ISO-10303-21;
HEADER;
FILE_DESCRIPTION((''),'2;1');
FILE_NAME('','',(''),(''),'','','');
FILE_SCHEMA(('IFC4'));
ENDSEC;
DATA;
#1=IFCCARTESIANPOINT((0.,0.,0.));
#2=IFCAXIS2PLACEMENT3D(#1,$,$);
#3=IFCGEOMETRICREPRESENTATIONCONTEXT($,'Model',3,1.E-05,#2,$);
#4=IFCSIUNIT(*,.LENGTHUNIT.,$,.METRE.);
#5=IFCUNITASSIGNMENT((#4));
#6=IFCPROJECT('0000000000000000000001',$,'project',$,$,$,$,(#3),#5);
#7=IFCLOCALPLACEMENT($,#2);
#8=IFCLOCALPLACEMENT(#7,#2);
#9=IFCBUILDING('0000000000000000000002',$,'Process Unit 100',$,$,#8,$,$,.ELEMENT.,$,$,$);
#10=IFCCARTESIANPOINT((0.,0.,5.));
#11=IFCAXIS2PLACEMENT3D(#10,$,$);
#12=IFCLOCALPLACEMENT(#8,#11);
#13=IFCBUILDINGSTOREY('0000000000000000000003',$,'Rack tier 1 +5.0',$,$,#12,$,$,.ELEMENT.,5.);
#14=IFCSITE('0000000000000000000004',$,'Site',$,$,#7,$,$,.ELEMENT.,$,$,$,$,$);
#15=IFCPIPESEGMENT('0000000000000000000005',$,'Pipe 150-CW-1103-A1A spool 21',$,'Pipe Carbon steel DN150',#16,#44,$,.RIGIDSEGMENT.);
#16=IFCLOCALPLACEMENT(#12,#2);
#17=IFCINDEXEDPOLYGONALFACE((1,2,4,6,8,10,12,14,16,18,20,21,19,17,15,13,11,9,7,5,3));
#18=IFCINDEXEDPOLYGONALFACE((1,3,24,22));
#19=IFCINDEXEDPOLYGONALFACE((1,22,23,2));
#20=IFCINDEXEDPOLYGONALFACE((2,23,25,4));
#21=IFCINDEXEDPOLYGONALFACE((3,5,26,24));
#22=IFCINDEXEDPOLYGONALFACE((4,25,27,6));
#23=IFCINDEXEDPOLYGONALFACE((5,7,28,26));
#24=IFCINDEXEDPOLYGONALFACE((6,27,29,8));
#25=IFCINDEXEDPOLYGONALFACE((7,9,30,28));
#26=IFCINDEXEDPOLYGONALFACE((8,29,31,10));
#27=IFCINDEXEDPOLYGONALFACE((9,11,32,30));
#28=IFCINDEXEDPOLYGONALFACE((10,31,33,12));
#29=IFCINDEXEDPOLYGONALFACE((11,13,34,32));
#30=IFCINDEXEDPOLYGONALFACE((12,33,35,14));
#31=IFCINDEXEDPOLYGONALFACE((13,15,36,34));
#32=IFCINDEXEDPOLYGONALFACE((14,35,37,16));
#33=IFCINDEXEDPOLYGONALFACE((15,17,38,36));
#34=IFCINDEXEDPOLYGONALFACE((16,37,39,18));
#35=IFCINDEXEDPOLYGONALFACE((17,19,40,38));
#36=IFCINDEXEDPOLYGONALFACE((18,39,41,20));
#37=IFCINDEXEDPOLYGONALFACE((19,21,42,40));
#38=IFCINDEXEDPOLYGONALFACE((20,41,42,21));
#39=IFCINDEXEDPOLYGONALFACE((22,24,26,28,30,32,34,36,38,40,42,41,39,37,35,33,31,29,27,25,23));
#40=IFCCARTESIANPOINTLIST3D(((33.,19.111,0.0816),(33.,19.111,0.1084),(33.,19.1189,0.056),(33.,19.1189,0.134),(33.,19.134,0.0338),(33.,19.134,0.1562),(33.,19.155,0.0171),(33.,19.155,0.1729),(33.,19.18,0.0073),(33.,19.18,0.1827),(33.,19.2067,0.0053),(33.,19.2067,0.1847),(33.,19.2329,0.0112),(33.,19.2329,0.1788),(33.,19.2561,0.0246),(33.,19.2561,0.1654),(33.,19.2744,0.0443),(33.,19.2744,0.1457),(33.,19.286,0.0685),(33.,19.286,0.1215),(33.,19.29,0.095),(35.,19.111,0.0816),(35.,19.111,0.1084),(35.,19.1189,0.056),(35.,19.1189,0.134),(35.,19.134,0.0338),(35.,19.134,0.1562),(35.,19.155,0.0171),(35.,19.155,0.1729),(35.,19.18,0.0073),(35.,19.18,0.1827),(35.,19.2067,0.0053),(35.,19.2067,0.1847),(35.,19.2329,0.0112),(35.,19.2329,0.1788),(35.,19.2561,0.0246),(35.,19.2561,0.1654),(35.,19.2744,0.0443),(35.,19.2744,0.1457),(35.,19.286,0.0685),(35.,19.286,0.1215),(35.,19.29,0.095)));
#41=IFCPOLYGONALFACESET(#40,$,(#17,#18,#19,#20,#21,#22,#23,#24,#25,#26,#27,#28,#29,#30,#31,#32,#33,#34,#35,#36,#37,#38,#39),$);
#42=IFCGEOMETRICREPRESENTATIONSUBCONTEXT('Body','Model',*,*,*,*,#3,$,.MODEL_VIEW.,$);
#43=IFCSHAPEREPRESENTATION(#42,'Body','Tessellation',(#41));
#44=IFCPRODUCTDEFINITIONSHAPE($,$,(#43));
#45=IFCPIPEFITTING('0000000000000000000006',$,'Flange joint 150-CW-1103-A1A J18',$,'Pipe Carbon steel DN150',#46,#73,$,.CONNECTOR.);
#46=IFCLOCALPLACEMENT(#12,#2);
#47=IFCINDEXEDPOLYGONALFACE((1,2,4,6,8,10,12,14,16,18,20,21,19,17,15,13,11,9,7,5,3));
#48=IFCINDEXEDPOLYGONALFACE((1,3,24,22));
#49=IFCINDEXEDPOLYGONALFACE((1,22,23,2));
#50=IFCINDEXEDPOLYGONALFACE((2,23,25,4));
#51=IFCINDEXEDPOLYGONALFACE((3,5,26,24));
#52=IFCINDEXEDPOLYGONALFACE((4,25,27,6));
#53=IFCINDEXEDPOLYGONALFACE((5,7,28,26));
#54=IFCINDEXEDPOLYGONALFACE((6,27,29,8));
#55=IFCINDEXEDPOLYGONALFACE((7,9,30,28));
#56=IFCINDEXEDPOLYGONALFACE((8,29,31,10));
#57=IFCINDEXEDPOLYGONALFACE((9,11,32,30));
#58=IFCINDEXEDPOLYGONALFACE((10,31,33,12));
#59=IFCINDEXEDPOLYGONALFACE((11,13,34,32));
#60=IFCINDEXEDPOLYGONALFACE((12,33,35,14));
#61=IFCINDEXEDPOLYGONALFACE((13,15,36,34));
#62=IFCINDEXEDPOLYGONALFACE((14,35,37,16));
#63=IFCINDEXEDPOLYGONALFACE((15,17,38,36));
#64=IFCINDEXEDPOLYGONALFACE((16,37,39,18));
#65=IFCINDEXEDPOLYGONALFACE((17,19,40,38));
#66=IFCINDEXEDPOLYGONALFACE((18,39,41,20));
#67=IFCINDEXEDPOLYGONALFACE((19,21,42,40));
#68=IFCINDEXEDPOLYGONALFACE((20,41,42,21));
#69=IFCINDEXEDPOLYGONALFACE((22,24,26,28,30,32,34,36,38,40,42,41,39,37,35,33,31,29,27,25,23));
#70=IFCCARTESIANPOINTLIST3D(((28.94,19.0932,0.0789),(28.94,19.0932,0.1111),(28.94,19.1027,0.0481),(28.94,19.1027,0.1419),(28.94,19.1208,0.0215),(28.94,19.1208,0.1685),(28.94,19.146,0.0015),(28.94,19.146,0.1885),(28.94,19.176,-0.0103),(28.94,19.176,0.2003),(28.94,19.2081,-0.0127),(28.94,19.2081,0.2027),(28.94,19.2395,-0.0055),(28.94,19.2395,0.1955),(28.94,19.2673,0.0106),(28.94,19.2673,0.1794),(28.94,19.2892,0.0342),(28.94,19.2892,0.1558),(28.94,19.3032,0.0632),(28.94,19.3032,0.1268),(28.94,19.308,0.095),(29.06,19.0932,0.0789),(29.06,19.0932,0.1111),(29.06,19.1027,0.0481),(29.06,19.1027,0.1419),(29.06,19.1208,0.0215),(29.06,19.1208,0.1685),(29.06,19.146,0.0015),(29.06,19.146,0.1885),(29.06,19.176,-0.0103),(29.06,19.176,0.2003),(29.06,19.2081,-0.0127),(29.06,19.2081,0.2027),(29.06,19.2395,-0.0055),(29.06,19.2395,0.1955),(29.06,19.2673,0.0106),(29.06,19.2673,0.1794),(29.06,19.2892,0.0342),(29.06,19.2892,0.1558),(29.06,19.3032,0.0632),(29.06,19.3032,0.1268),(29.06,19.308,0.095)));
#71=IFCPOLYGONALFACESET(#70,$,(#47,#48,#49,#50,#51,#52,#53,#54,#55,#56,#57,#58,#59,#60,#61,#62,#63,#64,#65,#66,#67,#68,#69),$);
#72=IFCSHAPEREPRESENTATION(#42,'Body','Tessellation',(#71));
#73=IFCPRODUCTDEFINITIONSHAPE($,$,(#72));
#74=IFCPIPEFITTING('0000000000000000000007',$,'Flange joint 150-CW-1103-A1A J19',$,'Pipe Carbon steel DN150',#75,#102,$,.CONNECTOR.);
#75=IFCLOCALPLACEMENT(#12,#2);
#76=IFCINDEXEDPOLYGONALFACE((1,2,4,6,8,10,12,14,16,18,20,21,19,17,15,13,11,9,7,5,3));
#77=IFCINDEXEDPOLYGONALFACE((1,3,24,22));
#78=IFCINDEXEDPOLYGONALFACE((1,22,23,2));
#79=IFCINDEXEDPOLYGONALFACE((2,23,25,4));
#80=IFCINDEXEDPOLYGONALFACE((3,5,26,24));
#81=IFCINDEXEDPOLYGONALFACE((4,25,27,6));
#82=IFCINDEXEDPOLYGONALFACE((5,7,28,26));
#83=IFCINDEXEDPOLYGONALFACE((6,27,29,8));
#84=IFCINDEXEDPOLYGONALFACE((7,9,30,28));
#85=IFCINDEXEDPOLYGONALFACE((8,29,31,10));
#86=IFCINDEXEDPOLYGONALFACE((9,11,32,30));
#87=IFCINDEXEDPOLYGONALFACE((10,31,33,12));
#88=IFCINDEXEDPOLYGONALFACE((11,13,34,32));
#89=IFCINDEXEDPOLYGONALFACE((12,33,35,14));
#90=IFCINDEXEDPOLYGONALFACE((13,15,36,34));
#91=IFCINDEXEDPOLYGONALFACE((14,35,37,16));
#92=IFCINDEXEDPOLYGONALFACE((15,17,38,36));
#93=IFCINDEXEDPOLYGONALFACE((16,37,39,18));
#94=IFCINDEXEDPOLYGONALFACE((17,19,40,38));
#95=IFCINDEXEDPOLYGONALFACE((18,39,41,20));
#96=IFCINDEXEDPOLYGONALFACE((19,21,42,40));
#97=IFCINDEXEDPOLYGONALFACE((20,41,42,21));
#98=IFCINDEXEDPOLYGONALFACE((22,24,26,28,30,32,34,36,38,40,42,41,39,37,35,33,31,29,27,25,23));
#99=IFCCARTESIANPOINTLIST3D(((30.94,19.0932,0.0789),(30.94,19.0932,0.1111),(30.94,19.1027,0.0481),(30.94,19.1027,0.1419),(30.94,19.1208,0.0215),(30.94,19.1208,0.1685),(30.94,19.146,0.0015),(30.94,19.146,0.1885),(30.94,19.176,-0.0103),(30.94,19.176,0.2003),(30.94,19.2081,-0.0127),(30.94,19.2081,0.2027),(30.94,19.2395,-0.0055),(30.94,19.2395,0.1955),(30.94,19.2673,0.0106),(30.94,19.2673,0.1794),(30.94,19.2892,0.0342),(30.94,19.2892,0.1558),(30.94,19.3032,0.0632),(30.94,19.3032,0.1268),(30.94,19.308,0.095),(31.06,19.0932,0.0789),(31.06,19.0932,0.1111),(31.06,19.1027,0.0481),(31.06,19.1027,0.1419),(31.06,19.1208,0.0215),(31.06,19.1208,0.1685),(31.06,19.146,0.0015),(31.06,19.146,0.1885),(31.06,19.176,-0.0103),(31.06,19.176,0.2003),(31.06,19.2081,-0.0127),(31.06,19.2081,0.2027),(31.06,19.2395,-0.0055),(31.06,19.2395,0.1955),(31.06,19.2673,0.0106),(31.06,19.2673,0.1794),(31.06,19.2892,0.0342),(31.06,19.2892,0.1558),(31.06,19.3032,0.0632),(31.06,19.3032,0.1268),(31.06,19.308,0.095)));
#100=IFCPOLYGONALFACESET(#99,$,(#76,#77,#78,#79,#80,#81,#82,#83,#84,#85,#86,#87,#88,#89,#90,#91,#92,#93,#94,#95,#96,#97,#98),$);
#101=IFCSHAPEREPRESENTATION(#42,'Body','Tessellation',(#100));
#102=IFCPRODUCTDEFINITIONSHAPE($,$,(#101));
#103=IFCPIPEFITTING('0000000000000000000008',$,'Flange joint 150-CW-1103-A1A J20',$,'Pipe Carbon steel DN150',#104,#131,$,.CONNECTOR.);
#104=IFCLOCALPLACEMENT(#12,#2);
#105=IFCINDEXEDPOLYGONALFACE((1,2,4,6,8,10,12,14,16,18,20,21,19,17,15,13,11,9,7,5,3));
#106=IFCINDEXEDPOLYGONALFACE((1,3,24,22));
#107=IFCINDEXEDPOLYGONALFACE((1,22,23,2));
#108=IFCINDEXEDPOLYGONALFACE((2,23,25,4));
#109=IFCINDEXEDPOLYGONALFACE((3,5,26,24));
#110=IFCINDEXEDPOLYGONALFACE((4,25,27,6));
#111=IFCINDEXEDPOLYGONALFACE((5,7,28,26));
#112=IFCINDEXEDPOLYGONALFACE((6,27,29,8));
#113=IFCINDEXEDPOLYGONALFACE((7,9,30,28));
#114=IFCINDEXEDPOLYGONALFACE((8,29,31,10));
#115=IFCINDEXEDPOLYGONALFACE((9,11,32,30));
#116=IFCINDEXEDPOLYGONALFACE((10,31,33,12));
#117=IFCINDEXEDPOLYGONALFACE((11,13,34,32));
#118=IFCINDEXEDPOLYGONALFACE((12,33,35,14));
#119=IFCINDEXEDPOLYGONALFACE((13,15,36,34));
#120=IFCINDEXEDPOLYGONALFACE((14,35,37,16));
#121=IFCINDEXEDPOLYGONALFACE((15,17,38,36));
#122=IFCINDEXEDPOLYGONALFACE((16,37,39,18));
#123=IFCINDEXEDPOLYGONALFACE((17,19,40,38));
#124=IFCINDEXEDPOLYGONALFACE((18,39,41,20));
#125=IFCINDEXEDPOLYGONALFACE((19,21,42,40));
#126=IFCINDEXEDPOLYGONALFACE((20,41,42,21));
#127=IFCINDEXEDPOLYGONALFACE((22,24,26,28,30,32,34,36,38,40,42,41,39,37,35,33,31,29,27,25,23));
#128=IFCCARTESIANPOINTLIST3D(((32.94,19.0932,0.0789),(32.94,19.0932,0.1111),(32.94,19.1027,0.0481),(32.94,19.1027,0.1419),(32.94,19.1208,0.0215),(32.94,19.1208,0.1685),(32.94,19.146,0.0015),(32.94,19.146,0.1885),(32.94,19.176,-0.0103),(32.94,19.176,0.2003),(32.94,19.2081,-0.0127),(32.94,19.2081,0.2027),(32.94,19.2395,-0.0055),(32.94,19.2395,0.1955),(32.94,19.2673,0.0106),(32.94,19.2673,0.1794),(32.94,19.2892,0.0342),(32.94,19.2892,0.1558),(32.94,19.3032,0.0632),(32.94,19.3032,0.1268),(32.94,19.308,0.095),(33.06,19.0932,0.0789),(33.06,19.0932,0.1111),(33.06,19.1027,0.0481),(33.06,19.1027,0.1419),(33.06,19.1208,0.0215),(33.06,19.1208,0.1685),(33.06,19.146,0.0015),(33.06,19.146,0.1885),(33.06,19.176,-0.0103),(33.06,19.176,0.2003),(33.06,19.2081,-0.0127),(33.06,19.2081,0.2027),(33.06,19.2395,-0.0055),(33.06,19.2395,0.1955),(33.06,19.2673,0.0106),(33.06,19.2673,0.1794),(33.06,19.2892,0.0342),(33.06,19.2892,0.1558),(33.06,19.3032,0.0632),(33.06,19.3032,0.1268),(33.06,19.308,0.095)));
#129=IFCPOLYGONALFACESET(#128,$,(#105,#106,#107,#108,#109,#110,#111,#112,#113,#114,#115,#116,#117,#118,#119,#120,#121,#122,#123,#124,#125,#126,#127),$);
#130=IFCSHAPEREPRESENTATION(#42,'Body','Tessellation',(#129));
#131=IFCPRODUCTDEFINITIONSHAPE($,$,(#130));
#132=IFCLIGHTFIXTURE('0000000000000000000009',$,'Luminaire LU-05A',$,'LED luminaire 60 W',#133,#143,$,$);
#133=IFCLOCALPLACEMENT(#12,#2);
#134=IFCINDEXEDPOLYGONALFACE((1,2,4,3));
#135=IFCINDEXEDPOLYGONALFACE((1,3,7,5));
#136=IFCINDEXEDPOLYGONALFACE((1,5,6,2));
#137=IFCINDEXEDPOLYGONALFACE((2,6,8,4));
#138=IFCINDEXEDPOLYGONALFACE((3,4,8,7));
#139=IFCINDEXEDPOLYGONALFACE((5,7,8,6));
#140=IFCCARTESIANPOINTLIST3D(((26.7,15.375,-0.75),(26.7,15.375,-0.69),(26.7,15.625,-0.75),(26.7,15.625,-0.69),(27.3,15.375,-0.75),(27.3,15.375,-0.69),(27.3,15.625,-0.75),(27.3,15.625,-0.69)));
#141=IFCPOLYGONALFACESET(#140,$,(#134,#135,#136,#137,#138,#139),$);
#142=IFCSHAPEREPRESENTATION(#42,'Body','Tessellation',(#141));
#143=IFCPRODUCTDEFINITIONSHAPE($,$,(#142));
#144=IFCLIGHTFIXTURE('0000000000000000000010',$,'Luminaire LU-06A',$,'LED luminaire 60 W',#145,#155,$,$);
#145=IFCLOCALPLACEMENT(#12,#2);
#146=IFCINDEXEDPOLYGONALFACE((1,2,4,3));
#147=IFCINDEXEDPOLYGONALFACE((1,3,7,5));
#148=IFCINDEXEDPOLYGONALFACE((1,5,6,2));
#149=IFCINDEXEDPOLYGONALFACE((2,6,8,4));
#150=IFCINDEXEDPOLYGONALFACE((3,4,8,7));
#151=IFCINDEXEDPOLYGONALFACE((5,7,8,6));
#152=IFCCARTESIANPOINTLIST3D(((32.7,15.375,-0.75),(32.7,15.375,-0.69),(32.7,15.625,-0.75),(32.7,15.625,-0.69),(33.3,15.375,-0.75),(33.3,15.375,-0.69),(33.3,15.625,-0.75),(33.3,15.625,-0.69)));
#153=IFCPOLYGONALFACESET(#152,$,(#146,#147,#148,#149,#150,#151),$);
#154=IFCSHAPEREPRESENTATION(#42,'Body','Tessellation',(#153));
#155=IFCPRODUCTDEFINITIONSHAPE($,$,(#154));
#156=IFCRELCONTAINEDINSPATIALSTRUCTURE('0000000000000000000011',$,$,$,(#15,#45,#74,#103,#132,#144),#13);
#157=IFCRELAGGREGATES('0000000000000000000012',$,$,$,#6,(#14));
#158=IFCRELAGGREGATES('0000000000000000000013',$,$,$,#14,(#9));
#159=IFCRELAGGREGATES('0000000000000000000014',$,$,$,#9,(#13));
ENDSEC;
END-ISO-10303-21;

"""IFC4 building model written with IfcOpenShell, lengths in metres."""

from ifc_helpers import new_model, si_unit, frame, origin, place, context, subcontext, project, spatial, rectangle, circle, extrude, element, save


model = new_model("IFC4")

# Units and contexts
model_context = context("Model", 3, precision=1e-05, world=origin())
body_context = subcontext(model_context, "Body", "Model", "MODEL_VIEW")
ifc_project = project(units=[si_unit("LENGTHUNIT", "METRE")], contexts=[model_context])

# Site, building, storey
site_placement = place(None, origin())
site = spatial("IfcSite", under=ifc_project, at=site_placement, Name="Site", CompositionType="ELEMENT")
building_placement = place(site_placement, origin())
building = spatial("IfcBuilding", under=site, at=building_placement, Name="Process Unit 100", CompositionType="ELEMENT")
storey_placement = place(building_placement, frame((0.0, 0.0, 5.0)))
storey = spatial("IfcBuildingStorey", under=building, at=storey_placement, Name="Rack tier 1 +5.0", CompositionType="ELEMENT", Elevation=5.0)

# Pipe segment
for number, where, z_axis, x_axis, name in (
    (1, (33.0, 19.2, 0.095), (1.0, 0.0, 0.0), (0.0, 1.0, 0.0), "Pipe 150-CW-1103-A1A spool 21"),
):
    element("IfcPipeSegment", number, at=place(storey_placement, frame(where, z_axis=z_axis, x_axis=x_axis)), inside=storey, Name=name, ObjectType="Pipe Carbon steel DN150", PredefinedType="RIGIDSEGMENT", context=body_context, shape_type="SweptSolid", body=[
        extrude(circle(Radius=0.09), origin(), (0.0, 0.0, 1.0), 2.0),
    ])

# Pipe fittings
for number, where, z_axis, x_axis, name in (
    (2, (28.94, 19.2, 0.095), (1.0, 0.0, 0.0), (0.0, 1.0, 0.0), "Flange joint 150-CW-1103-A1A J18"),
    (3, (30.94, 19.2, 0.095), (1.0, 0.0, 0.0), (0.0, 1.0, 0.0), "Flange joint 150-CW-1103-A1A J19"),
    (4, (32.94, 19.2, 0.095), (1.0, 0.0, 0.0), (0.0, 1.0, 0.0), "Flange joint 150-CW-1103-A1A J20"),
):
    element("IfcPipeFitting", number, at=place(storey_placement, frame(where, z_axis=z_axis, x_axis=x_axis)), inside=storey, Name=name, ObjectType="Pipe Carbon steel DN150", PredefinedType="CONNECTOR", context=body_context, shape_type="SweptSolid", body=[
        extrude(circle(Radius=0.108), origin(), (0.0, 0.0, 1.0), 0.12),
    ])

# Light fixtures
for number, where, z_axis, x_axis, name in (
    (5, (27.0, 15.5, -0.75), (0.0, 0.0, 1.0), (1.0, 0.0, 0.0), "Luminaire LU-05A"),
    (6, (33.0, 15.5, -0.75), (0.0, 0.0, 1.0), (1.0, 0.0, 0.0), "Luminaire LU-06A"),
):
    element("IfcLightFixture", number, at=place(storey_placement, frame(where, z_axis=z_axis, x_axis=x_axis)), inside=storey, Name=name, ObjectType="LED luminaire 60 W", context=body_context, shape_type="SweptSolid", body=[
        extrude(rectangle(XDim=0.6, YDim=0.25), origin(), (0.0, 0.0, 1.0), 0.06),
    ])

save(model, "model.ifc")
